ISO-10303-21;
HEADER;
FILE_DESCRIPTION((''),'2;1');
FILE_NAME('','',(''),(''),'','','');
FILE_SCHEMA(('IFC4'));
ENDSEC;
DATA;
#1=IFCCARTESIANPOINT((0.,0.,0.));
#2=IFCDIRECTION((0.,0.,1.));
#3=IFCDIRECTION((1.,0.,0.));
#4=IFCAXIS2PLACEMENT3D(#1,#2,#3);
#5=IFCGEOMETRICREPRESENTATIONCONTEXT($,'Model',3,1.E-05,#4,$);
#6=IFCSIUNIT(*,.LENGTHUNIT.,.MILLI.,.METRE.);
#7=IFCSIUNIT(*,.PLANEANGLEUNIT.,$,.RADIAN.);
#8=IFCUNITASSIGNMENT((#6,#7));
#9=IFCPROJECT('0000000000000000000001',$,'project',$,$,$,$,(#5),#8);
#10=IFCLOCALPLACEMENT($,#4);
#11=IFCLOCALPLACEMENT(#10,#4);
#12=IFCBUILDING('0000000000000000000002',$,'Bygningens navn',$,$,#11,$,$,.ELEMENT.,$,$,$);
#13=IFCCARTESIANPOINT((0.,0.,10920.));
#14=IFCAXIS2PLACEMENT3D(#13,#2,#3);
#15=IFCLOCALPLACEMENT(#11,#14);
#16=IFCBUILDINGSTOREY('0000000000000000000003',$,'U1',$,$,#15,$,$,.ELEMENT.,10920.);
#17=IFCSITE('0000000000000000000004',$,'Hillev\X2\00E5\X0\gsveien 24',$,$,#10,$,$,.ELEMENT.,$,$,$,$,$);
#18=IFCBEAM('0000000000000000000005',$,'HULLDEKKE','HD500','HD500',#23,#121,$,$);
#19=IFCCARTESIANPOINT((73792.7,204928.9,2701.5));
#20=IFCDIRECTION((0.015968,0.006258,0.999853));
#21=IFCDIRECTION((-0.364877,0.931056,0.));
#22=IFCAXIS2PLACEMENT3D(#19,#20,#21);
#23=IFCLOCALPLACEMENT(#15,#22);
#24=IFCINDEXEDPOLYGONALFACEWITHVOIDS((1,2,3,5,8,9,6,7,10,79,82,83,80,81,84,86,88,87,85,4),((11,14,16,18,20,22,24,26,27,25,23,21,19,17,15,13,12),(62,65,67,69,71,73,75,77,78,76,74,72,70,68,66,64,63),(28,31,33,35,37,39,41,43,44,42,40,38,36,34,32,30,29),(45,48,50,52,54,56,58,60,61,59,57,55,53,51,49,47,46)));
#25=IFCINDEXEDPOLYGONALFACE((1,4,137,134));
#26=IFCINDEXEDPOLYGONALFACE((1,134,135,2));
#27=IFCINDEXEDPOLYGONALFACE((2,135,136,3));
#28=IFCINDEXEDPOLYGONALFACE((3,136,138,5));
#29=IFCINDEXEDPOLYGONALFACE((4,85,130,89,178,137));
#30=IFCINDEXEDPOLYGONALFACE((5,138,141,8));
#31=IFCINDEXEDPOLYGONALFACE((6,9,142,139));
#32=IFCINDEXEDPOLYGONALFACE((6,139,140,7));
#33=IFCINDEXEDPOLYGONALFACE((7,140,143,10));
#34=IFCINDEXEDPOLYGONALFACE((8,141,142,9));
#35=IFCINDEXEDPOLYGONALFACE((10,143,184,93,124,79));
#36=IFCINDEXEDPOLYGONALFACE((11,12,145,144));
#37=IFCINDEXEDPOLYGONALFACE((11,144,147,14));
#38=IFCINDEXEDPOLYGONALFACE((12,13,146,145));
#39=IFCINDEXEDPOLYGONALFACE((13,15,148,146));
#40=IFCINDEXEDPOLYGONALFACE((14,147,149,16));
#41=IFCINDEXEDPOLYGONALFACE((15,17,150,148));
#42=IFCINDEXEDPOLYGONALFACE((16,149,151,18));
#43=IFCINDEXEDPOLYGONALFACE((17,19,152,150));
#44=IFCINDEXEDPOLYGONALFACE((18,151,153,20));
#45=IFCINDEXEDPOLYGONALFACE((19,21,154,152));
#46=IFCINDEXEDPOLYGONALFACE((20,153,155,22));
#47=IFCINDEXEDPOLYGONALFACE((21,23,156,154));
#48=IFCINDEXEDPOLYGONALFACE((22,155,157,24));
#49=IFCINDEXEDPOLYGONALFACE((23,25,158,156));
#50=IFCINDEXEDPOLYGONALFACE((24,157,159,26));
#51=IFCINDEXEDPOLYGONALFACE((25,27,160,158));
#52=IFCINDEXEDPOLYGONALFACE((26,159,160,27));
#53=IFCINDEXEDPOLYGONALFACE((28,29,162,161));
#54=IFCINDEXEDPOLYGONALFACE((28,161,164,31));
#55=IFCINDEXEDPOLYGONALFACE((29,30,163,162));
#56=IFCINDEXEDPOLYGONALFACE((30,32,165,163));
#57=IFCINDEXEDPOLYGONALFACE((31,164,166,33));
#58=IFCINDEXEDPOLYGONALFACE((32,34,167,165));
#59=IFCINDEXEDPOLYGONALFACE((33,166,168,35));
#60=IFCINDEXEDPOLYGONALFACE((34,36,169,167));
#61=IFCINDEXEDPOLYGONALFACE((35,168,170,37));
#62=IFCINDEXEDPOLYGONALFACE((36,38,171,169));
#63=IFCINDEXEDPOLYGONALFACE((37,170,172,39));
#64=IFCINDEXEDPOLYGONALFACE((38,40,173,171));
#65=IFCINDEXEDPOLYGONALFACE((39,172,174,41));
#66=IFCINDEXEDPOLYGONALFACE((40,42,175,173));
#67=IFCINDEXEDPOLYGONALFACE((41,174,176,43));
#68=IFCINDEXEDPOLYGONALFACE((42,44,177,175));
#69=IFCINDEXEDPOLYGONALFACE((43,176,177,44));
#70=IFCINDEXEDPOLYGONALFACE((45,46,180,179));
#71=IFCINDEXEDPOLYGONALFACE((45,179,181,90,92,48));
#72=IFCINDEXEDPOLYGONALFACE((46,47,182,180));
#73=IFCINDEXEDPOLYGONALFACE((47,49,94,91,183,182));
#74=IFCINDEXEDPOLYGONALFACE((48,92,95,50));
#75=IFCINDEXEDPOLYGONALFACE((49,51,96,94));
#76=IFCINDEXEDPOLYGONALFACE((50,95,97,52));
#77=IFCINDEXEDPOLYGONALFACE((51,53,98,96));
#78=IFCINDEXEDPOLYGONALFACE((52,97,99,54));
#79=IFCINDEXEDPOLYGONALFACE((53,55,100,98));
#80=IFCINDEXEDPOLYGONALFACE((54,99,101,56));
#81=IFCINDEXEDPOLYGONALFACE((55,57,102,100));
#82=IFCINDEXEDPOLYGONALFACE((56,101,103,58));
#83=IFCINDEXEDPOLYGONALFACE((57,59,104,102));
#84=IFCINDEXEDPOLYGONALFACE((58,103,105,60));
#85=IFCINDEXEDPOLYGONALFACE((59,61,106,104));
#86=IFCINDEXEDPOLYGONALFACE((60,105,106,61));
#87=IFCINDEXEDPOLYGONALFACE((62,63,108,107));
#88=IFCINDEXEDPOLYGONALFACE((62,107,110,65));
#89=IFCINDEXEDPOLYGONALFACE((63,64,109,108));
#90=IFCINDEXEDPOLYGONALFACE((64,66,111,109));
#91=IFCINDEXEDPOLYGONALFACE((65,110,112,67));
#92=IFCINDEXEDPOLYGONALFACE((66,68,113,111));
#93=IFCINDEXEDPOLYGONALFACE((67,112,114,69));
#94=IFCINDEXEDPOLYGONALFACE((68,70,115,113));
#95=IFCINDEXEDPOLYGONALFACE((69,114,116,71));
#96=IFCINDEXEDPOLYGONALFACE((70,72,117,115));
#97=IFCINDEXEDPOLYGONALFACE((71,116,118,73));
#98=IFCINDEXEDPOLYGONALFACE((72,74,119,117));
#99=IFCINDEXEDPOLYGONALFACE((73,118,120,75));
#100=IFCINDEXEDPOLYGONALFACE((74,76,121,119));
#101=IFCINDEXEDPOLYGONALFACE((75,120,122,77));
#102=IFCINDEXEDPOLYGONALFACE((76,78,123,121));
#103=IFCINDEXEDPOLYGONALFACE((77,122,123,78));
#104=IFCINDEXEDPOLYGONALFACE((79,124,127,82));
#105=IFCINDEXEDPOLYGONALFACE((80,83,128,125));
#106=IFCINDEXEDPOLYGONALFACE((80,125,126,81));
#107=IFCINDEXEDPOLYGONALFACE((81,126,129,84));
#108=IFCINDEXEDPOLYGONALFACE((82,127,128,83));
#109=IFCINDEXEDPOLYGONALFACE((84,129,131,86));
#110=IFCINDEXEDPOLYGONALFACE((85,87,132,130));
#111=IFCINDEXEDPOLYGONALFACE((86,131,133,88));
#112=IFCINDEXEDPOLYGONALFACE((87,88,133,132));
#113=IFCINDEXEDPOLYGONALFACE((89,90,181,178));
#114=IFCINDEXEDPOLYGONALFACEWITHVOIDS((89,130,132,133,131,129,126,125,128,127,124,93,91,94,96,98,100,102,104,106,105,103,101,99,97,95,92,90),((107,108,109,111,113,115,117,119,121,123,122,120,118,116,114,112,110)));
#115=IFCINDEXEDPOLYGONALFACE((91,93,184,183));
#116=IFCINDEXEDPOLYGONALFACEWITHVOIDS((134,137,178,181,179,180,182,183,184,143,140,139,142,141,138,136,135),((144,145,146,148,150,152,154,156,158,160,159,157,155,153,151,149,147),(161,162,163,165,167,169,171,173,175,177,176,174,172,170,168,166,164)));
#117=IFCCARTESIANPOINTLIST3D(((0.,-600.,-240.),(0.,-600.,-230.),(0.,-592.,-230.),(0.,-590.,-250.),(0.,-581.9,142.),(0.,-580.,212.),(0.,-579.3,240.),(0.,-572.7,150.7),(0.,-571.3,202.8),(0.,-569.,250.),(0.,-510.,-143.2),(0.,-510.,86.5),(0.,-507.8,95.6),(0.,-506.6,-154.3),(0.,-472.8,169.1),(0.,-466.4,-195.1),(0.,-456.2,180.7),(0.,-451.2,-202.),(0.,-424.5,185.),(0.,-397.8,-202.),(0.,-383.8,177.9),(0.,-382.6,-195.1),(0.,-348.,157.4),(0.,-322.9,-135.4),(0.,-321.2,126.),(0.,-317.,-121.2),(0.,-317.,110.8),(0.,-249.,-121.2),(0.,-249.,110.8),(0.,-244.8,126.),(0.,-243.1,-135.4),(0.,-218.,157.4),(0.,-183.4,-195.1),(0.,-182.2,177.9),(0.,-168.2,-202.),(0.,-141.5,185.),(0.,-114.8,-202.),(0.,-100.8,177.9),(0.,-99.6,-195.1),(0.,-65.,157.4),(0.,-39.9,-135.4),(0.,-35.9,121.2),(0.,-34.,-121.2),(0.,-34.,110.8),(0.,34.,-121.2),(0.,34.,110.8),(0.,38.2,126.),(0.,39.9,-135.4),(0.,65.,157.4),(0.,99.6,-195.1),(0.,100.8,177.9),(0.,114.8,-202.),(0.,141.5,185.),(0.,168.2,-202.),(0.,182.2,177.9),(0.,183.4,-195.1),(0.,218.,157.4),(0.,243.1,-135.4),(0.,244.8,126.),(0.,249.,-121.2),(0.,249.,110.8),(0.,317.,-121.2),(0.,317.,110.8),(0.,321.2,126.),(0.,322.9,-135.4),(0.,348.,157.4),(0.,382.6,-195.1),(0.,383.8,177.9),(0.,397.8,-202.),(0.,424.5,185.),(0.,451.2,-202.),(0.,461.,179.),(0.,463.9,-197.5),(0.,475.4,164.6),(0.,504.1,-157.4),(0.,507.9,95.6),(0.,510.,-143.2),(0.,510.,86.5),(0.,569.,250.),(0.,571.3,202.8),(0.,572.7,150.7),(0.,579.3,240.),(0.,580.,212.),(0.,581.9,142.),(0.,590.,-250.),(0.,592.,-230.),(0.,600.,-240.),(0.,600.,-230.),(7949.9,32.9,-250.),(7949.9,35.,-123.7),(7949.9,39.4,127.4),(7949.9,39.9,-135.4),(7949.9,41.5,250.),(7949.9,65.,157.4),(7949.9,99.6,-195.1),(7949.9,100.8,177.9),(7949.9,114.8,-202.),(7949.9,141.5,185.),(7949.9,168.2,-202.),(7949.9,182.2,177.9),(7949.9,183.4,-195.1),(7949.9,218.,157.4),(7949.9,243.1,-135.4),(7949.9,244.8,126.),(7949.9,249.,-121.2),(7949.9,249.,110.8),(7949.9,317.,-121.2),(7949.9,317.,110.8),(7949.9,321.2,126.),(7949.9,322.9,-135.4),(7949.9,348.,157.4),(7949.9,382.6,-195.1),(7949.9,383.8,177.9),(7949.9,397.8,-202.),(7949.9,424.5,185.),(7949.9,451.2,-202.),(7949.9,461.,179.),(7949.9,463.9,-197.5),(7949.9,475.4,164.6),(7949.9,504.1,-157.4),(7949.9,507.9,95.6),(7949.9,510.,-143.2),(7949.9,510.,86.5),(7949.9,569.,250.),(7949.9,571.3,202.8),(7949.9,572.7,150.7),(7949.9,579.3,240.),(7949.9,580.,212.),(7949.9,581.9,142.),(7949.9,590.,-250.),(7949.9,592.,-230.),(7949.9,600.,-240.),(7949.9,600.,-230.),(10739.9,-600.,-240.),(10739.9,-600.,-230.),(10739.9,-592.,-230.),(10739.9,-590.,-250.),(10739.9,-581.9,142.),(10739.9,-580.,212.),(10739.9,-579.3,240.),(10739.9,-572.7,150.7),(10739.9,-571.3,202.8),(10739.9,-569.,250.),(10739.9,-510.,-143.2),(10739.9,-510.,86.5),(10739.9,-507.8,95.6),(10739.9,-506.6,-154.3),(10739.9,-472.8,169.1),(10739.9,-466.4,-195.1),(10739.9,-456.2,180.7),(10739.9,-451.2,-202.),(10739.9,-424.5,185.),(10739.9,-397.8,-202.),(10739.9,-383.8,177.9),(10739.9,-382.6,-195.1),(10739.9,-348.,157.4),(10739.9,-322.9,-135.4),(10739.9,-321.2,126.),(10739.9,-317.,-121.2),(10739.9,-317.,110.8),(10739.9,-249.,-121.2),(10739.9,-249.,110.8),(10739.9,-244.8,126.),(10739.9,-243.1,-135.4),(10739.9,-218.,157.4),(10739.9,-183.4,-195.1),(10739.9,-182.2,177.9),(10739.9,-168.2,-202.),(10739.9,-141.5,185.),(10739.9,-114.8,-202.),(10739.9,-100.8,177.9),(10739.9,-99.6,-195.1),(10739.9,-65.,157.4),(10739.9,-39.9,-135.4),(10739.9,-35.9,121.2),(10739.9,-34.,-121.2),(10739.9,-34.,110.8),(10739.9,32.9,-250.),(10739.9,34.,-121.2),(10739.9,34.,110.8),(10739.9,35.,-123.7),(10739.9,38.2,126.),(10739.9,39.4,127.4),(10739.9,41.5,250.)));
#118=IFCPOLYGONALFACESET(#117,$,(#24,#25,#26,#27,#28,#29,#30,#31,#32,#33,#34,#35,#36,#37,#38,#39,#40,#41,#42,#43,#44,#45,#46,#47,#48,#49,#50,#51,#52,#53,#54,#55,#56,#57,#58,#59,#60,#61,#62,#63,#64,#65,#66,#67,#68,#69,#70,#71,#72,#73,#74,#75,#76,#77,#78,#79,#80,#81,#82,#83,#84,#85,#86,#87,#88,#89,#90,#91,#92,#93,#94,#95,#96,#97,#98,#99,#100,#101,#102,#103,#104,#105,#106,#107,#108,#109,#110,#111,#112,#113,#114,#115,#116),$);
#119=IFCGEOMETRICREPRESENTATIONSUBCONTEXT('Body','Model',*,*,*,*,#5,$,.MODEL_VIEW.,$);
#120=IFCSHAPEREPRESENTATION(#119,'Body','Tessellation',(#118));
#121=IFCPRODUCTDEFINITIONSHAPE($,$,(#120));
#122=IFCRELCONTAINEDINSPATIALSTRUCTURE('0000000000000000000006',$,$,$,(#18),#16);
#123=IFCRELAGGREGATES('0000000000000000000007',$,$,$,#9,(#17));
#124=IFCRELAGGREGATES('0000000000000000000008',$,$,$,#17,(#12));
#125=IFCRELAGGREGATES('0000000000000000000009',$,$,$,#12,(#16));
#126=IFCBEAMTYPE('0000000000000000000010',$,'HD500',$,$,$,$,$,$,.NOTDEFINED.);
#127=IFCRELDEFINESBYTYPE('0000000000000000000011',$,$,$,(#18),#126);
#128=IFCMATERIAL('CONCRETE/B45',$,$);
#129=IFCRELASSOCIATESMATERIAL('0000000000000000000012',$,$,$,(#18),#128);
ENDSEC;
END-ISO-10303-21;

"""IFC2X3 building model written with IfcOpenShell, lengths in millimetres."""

from ifc_helpers import new_model, si_unit, frame, origin_with_axes, place, context, subcontext, project, spatial, polyline, outline, extrude, boolean, material, type_object, element, save


model = new_model("IFC2X3")

# Units and contexts
model_context = context("Model", 3, precision=1e-05, world=origin_with_axes())
body_context = subcontext(model_context, "Body", "Model", "MODEL_VIEW")
ifc_project = project(units=[si_unit("LENGTHUNIT", "METRE", prefix="MILLI"), si_unit("PLANEANGLEUNIT", "RADIAN")], contexts=[model_context])

# Site, building, storey
site_placement = place(None, origin_with_axes())
site = spatial("IfcSite", under=ifc_project, at=site_placement, Name="Hillevågsveien 24", CompositionType="ELEMENT")
building_placement = place(site_placement, origin_with_axes())
building = spatial("IfcBuilding", under=site, at=building_placement, Name="Bygningens navn", CompositionType="ELEMENT")
storey_placement = place(building_placement, frame((0.0, 0.0, 10920.0), z_axis=(0.0, 0.0, 1.0), x_axis=(1.0, 0.0, 0.0)))
storey = spatial("IfcBuildingStorey", under=building, at=storey_placement, Name="U1", CompositionType="ELEMENT", Elevation=10920.0)

# Beam
ifc_material_1 = material(Name="CONCRETE/B45")
beam_type_1 = type_object("IfcBeamType", Name="HD500", PredefinedType="NOTDEFINED")
beam_1_placement = place(storey_placement, frame((73792.7, 204928.9, 2701.5), z_axis=(0.015968, 0.006258, 0.999853), x_axis=(-0.364877, 0.931056, 0.0)))
element("IfcBeam", 1, at=beam_1_placement, inside=storey, type_object=beam_type_1, material=ifc_material_1, Name="HULLDEKKE", Description="HD500", ObjectType="HD500", context=body_context, shape_type="CSG", body=[
    boolean("DIFFERENCE", extrude(outline(polyline([(581.9, 142.0), (592.0, -230.0), (600.0, -230.0), (600.0, -240.0), (590.0, -250.0), (-590.0, -250.0), (-600.0, -240.0), (-600.0, -230.0), (-592.0, -230.0), (-581.9, 142.0), (-572.7, 150.7), (-571.3, 202.8), (-580.0, 212.0), (-579.3, 240.0), (-569.0, 250.0), (569.0, 250.0), (579.3, 240.0), (580.0, 212.0), (571.3, 202.8), (572.7, 150.7), (581.9, 142.0)]), holes=[polyline([(466.4, -195.1), (506.6, -154.3), (510.0, -143.2), (510.0, 86.5), (507.8, 95.6), (472.8, 169.1), (456.2, 180.7), (424.5, 185.0), (383.8, 177.9), (348.0, 157.4), (321.2, 126.0), (317.0, 110.8), (317.0, -121.2), (322.9, -135.4), (382.6, -195.1), (397.8, -202.0), (451.2, -202.0), (466.4, -195.1)]), polyline([(183.4, -195.1), (243.1, -135.4), (249.0, -121.2), (249.0, 110.8), (244.8, 126.0), (218.0, 157.4), (182.2, 177.9), (141.5, 185.0), (100.8, 177.9), (65.0, 157.4), (35.9, 121.2), (34.0, 110.8), (34.0, -121.2), (39.9, -135.4), (99.6, -195.1), (114.8, -202.0), (168.2, -202.0), (183.4, -195.1)]), polyline([(-99.6, -195.1), (-39.9, -135.4), (-34.0, -121.2), (-34.0, 110.8), (-38.2, 126.0), (-65.0, 157.4), (-100.8, 177.9), (-141.5, 185.0), (-182.2, 177.9), (-218.0, 157.4), (-244.8, 126.0), (-249.0, 110.8), (-249.0, -121.2), (-243.1, -135.4), (-183.4, -195.1), (-168.2, -202.0), (-114.8, -202.0), (-99.6, -195.1)]), polyline([(-382.6, -195.1), (-322.9, -135.4), (-317.0, -121.2), (-317.0, 110.8), (-321.2, 126.0), (-348.0, 157.4), (-383.8, 177.9), (-424.5, 185.0), (-461.0, 179.0), (-475.4, 164.6), (-507.9, 95.6), (-510.0, 86.5), (-510.0, -143.2), (-504.1, -157.4), (-463.9, -197.5), (-451.2, -202.0), (-397.8, -202.0), (-382.6, -195.1)])]), frame((10739.9, 0.0, 0.0), z_axis=(-1.0, 0.0, 0.0), x_axis=(0.0, -1.0, 0.0)), (0.0, 0.0, 1.0), 10739.9), extrude(outline(polyline([(0.0, 0.0), (800.0, 0.0), (800.0, 2890.0), (0.0, 2890.0), (0.0, 0.0)])), frame((10839.9, 32.7, -263.3), z_axis=(0.0, 0.01715, 0.999853), x_axis=(-0.000001, 0.999853, -0.01715)), (0.0, 0.0, 1.0), 525.0)),
])

save(model, "model.ifc")
